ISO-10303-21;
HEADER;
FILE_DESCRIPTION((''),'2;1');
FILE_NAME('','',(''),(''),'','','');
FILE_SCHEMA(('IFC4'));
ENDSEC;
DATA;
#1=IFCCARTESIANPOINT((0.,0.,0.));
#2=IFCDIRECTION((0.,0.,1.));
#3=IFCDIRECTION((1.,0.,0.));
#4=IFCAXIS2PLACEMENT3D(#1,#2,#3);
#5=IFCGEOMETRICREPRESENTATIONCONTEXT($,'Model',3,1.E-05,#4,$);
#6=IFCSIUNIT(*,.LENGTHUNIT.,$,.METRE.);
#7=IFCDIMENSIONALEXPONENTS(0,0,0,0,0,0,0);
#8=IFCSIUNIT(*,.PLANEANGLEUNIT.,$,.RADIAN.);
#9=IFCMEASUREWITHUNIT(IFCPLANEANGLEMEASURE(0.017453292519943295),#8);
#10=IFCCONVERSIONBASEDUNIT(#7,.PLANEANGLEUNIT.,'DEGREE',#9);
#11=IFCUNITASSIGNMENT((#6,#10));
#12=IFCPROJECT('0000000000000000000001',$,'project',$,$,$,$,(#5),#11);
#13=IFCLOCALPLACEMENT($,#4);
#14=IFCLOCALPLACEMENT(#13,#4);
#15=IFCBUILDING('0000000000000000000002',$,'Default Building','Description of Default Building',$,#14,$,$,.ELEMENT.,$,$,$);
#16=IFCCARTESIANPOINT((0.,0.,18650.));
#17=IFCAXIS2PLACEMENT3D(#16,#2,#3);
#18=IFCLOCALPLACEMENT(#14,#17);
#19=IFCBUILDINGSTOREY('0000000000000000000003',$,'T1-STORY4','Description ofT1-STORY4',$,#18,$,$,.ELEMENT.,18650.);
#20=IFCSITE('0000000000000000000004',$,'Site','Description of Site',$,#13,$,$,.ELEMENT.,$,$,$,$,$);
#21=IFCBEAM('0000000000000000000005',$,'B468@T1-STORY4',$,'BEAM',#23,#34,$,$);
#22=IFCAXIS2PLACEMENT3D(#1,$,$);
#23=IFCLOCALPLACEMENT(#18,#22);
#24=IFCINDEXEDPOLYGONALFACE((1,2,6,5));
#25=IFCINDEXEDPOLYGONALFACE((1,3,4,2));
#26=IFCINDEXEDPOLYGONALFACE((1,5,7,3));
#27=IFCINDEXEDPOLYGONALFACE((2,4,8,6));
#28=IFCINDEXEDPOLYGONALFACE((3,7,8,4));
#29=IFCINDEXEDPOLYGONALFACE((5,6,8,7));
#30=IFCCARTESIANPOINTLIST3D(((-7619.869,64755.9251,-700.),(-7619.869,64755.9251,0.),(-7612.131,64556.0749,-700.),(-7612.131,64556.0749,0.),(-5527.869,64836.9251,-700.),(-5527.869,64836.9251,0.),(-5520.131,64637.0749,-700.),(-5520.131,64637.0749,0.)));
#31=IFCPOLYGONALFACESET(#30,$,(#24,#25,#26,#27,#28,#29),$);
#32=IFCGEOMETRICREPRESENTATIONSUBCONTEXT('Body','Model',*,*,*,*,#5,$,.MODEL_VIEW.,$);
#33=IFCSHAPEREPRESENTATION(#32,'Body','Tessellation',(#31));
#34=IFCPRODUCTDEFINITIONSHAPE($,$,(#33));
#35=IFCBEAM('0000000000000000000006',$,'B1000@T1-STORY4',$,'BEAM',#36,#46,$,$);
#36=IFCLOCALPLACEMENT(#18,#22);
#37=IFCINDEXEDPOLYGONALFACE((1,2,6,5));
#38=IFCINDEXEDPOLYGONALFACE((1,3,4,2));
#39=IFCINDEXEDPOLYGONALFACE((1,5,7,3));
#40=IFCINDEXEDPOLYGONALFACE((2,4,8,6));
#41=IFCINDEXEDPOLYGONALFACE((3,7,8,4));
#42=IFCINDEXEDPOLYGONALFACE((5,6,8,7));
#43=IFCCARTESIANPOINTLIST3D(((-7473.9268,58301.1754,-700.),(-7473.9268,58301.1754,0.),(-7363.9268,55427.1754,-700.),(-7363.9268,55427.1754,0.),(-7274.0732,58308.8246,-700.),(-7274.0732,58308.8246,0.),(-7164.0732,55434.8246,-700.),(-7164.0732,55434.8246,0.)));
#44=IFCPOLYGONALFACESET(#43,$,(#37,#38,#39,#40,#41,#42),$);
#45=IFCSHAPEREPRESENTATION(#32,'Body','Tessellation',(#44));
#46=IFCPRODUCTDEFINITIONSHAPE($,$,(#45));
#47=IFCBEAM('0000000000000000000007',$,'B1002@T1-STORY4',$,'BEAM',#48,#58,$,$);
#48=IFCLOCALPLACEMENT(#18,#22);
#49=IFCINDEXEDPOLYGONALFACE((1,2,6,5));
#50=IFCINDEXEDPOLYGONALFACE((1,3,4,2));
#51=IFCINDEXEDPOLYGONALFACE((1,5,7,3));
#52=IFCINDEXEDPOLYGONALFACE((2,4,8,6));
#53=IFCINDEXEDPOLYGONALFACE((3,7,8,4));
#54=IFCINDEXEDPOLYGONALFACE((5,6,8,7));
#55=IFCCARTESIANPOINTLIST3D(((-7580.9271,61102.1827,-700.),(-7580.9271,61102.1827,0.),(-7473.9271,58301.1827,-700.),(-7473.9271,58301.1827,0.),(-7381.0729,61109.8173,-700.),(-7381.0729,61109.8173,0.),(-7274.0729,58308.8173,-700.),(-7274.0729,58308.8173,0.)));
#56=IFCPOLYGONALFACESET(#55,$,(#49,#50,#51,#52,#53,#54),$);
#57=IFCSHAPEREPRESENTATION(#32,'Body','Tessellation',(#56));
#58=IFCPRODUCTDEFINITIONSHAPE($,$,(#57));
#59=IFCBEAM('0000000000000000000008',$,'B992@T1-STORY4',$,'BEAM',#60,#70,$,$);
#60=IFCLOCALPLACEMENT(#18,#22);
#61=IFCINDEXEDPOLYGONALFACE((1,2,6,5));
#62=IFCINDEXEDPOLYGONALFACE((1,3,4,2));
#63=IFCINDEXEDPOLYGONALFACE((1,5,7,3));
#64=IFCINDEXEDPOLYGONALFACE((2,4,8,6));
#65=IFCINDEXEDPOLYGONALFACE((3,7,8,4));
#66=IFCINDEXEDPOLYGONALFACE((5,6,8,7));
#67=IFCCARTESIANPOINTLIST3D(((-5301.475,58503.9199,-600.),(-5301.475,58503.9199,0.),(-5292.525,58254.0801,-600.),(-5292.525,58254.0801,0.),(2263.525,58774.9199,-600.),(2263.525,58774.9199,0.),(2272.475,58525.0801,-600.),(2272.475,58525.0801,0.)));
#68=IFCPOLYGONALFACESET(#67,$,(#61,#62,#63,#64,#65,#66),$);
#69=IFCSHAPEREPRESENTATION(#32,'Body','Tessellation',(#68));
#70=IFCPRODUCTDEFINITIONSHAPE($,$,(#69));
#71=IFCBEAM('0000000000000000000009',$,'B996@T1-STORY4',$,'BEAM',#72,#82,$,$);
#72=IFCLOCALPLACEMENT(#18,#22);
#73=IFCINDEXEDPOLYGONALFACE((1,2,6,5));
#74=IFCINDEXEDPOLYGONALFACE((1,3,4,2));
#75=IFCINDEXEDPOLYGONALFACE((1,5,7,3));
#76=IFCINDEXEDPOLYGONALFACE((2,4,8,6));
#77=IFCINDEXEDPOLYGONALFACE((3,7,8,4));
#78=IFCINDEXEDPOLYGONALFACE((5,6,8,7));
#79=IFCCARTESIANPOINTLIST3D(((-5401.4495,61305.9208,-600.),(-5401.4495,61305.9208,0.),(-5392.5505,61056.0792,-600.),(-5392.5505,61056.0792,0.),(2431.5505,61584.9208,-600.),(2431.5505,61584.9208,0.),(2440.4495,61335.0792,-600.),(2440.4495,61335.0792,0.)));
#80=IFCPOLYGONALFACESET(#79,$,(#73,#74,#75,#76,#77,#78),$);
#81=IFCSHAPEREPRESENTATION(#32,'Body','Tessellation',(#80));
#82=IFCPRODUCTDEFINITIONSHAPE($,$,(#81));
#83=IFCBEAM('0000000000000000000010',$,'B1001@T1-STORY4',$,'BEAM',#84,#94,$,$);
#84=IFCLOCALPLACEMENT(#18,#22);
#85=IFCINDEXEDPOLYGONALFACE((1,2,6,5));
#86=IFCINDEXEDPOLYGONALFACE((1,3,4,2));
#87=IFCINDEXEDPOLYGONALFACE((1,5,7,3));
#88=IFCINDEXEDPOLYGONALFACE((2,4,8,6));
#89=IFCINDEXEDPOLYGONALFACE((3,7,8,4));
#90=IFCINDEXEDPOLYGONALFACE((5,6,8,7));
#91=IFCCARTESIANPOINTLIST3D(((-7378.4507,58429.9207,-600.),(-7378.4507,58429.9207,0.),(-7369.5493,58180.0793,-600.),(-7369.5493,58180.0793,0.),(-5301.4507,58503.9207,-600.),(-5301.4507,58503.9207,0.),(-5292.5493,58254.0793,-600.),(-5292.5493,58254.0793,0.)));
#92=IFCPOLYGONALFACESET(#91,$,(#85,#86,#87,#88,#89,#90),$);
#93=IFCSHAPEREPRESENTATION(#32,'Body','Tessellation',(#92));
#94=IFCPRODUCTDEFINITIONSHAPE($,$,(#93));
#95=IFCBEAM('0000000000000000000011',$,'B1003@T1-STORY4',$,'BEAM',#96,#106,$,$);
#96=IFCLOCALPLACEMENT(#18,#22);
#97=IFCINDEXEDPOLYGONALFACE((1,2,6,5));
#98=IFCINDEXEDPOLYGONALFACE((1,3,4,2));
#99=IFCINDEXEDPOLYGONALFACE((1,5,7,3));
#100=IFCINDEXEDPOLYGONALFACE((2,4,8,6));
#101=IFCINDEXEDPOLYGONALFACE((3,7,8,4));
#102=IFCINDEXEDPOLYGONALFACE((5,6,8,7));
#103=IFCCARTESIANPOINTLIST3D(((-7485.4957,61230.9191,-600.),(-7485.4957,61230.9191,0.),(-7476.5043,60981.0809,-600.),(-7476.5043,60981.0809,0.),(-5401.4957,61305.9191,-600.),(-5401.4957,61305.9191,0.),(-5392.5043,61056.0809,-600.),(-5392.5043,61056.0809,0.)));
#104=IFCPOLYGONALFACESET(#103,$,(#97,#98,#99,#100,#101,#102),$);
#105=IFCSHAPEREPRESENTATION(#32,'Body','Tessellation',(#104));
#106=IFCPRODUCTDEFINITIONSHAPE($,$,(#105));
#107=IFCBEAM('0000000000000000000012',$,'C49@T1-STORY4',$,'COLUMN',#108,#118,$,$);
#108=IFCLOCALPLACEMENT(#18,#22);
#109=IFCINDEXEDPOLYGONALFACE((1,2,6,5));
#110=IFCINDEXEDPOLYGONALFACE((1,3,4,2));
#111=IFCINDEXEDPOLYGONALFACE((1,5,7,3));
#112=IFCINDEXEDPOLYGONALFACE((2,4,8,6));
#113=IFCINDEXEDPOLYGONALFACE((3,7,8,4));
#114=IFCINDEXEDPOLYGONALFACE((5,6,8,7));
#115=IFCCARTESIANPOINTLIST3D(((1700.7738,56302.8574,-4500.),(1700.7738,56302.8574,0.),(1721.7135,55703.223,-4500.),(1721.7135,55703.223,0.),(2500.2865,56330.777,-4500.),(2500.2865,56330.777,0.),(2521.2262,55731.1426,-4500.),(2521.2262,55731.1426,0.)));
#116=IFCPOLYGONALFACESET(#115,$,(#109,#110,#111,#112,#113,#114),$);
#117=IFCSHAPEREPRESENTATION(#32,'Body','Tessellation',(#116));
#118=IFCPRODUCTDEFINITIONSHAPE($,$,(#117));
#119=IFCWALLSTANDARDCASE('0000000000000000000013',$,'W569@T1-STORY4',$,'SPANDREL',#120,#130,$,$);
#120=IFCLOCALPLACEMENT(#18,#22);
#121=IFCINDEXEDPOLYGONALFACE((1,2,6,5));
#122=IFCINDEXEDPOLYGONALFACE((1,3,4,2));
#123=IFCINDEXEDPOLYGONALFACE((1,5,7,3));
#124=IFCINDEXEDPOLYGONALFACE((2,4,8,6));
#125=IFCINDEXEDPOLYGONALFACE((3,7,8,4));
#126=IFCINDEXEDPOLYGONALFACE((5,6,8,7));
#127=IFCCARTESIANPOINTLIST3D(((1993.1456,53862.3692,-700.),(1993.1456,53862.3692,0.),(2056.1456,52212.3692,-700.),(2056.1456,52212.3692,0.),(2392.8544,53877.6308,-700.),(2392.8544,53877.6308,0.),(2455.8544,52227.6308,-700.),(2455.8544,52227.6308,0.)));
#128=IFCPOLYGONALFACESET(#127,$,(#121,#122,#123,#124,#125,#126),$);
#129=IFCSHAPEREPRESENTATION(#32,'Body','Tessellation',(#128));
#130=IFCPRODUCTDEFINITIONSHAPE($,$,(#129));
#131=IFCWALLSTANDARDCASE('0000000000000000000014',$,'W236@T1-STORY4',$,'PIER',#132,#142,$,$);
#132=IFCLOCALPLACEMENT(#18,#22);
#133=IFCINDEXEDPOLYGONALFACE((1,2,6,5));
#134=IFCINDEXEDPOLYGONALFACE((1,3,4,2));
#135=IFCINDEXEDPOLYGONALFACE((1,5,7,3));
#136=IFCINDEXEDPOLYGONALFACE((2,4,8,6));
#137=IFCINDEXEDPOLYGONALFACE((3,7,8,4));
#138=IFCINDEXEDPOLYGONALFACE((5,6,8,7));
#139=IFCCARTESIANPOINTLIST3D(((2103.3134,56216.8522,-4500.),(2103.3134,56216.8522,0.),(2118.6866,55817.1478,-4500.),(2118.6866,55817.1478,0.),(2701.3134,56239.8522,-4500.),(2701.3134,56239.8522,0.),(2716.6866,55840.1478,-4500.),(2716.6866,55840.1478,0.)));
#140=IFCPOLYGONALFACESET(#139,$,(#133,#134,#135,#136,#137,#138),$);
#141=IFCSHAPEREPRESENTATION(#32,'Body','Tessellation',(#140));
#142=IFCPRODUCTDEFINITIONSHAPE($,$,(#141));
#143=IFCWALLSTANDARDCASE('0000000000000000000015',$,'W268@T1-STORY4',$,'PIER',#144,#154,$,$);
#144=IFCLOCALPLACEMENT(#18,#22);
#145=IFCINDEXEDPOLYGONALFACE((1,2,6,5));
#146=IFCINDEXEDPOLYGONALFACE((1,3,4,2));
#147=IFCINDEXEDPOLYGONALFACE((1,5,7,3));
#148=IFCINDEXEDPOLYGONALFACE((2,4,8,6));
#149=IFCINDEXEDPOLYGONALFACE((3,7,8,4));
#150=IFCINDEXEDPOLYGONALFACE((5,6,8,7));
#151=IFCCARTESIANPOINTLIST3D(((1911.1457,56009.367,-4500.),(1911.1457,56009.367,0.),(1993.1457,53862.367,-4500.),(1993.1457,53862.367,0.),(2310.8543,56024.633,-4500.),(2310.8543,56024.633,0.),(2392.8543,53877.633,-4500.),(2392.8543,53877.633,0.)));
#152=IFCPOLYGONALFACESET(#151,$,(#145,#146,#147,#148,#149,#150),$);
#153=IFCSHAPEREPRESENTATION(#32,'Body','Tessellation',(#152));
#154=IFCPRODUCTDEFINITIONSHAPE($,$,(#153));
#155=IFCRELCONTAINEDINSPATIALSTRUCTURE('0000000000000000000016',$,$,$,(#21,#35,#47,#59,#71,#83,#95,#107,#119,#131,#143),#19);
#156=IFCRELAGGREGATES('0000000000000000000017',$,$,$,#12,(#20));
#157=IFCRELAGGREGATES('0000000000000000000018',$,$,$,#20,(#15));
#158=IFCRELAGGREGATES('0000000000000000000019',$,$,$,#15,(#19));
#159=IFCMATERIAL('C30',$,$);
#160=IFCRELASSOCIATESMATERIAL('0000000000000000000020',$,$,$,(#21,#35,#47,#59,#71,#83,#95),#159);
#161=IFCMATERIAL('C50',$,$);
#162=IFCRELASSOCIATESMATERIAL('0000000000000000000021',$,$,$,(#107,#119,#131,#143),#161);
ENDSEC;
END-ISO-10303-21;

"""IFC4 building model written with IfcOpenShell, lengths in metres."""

from ifc_helpers import new_model, entity, si_unit, converted_unit, frame, origin_with_axes, place, context, subcontext, project, spatial, indexed_curve, rectangle, outline, extrude, material, element, save


model = new_model("IFC4")

# Units and contexts
model_context = context("Model", 3, precision=1e-05, world=origin_with_axes())
body_context = subcontext(model_context, "Body", "Model", "MODEL_VIEW")
ifc_project = project(units=[si_unit("LENGTHUNIT", "METRE"), converted_unit("PLANEANGLEUNIT", "DEGREE", entity("IfcPlaneAngleMeasure", 0.017453292519943295), si_unit("PLANEANGLEUNIT", "RADIAN"), dimensions=[0, 0, 0, 0, 0, 0, 0])], contexts=[model_context])

# Site, building, storey
site_placement = place(None, origin_with_axes())
site = spatial("IfcSite", under=ifc_project, at=site_placement, Name="Site", Description="Description of Site", CompositionType="ELEMENT")
building_placement = place(site_placement, origin_with_axes())
building = spatial("IfcBuilding", under=site, at=building_placement, Name="Default Building", Description="Description of Default Building", CompositionType="ELEMENT")
storey_placement = place(building_placement, frame((0.0, 0.0, 18650.0), z_axis=(0.0, 0.0, 1.0), x_axis=(1.0, 0.0, 0.0)))
storey = spatial("IfcBuildingStorey", under=building, at=storey_placement, Name="T1-STORY4", Description="Description ofT1-STORY4", CompositionType="ELEMENT", Elevation=18650.0)

# Beams
ifc_material_1 = material(Name="C30")
beam_1_placement = place(storey_placement, frame((-7616.0, 64656.0, -350.0), z_axis=(0.999251, 0.03869, 0.0), x_axis=(-0.03869, 0.999251, 0.0)))
element("IfcBeam", 1, at=beam_1_placement, inside=storey, material=ifc_material_1, Name="B468@T1-STORY4", ObjectType="BEAM", context=body_context, shape_type="SweptSolid", body=[
    extrude(rectangle(XDim=200.0, YDim=700.0), origin_with_axes(), (0.0, 0.0, 1.0), 2093.5675),
])
beam_2_placement = place(storey_placement, frame((-7374.0, 58305.0, -350.0), z_axis=(0.038246, -0.999268, 0.0), x_axis=(0.999268, 0.038246, 0.0)))
element("IfcBeam", 2, at=beam_2_placement, inside=storey, material=ifc_material_1, Name="B1000@T1-STORY4", ObjectType="BEAM", context=body_context, shape_type="SweptSolid", body=[
    extrude(rectangle(XDim=200.0, YDim=700.0), origin_with_axes(), (0.0, 0.0, 1.0), 2876.1043),
])
beam_3_placement = place(storey_placement, frame((-7481.0, 61106.0, -350.0), z_axis=(0.038173, -0.999271, 0.0), x_axis=(0.999271, 0.038173, 0.0)))
element("IfcBeam", 3, at=beam_3_placement, inside=storey, material=ifc_material_1, Name="B1002@T1-STORY4", ObjectType="BEAM", context=body_context, shape_type="SweptSolid", body=[
    extrude(rectangle(XDim=200.0, YDim=700.0), origin_with_axes(), (0.0, 0.0, 1.0), 2803.043),
])
beam_4_placement = place(storey_placement, frame((-5297.0, 58379.0, -300.0), z_axis=(0.999359, 0.0358, 0.0), x_axis=(-0.0358, 0.999359, 0.0)))
element("IfcBeam", 4, at=beam_4_placement, inside=storey, material=ifc_material_1, Name="B992@T1-STORY4", ObjectType="BEAM", context=body_context, shape_type="SweptSolid", body=[
    extrude(rectangle(XDim=250.0, YDim=600.0), origin_with_axes(), (0.0, 0.0, 1.0), 7569.8524),
])
beam_5_placement = place(storey_placement, frame((-5397.0, 61181.0, -300.0), z_axis=(0.999366, 0.035596, 0.0), x_axis=(-0.035596, 0.999366, 0.0)))
element("IfcBeam", 5, at=beam_5_placement, inside=storey, material=ifc_material_1, Name="B996@T1-STORY4", ObjectType="BEAM", context=body_context, shape_type="SweptSolid", body=[
    extrude(rectangle(XDim=250.0, YDim=600.0), origin_with_axes(), (0.0, 0.0, 1.0), 7837.9672),
])
beam_6_placement = place(storey_placement, frame((-7374.0, 58305.0, -300.0), z_axis=(0.999366, 0.035606, 0.0), x_axis=(-0.035606, 0.999366, 0.0)))
element("IfcBeam", 6, at=beam_6_placement, inside=storey, material=ifc_material_1, Name="B1001@T1-STORY4", ObjectType="BEAM", context=body_context, shape_type="SweptSolid", body=[
    extrude(rectangle(XDim=250.0, YDim=600.0), origin_with_axes(), (0.0, 0.0, 1.0), 2078.3178),
])
beam_7_placement = place(storey_placement, frame((-7481.0, 61106.0, -300.0), z_axis=(0.999353, 0.035965, 0.0), x_axis=(-0.035965, 0.999353, 0.0)))
element("IfcBeam", 7, at=beam_7_placement, inside=storey, material=ifc_material_1, Name="B1003@T1-STORY4", ObjectType="BEAM", context=body_context, shape_type="SweptSolid", body=[
    extrude(rectangle(XDim=250.0, YDim=600.0), origin_with_axes(), (0.0, 0.0, 1.0), 2085.3491),
])
ifc_material_2 = material(Name="C50")
beam_8_placement = place(storey_placement, frame((2111.0, 56017.0, -4500.0), z_axis=(0.0, 0.0, 1.0), x_axis=(-0.999391, -0.034899, 0.0)))
element("IfcBeam", 8, at=beam_8_placement, inside=storey, material=ifc_material_2, Name="C49@T1-STORY4", ObjectType="COLUMN", context=body_context, shape_type="SweptSolid", body=[
    extrude(rectangle(XDim=800.0, YDim=600.0), origin_with_axes(), (0.0, 0.0, 1.0), 4500.0),
])

# Walls
wall_1_placement = place(storey_placement, frame((2193.0, 53870.0, -700.0), z_axis=(0.0, 0.0, 1.0), x_axis=(0.038154, -0.999272, 0.0)))
element("IfcWallStandardCase", 9, at=wall_1_placement, inside=storey, material=ifc_material_2, Name="W569@T1-STORY4", ObjectType="SPANDREL", context=body_context, shape_type="SweptSolid", body=[
    extrude(outline(indexed_curve([(0.0, -200.0), (0.0, 200.0), (1651.2023, 200.0), (1651.2023, -200.0), (0.0, -200.0)], self_intersect=False)), origin_with_axes(), (0.0, 0.0, 1.0), 700.0),
])
wall_2_placement = place(storey_placement, frame((2111.0, 56017.0, -4500.0), z_axis=(0.0, 0.0, 1.0), x_axis=(0.999261, 0.038433, 0.0)))
element("IfcWallStandardCase", 10, at=wall_2_placement, inside=storey, material=ifc_material_2, Name="W236@T1-STORY4", ObjectType="PIER", context=body_context, shape_type="SweptSolid", body=[
    extrude(outline(indexed_curve([(0.0, -200.0), (0.0, 200.0), (598.4421, 200.0), (598.4421, -200.0), (0.0, -200.0)], self_intersect=False)), origin_with_axes(), (0.0, 0.0, 1.0), 4500.0),
])
wall_3_placement = place(storey_placement, frame((2111.0, 56017.0, -4500.0), z_axis=(0.0, 0.0, 1.0), x_axis=(0.038165, -0.999271, 0.0)))
element("IfcWallStandardCase", 11, at=wall_3_placement, inside=storey, material=ifc_material_2, Name="W268@T1-STORY4", ObjectType="PIER", context=body_context, shape_type="SweptSolid", body=[
    extrude(outline(indexed_curve([(0.0, -200.0), (0.0, 200.0), (2148.5653, 200.0), (2148.5653, -200.0), (0.0, -200.0)], self_intersect=False)), origin_with_axes(), (0.0, 0.0, 1.0), 4500.0),
])

save(model, "model.ifc")
